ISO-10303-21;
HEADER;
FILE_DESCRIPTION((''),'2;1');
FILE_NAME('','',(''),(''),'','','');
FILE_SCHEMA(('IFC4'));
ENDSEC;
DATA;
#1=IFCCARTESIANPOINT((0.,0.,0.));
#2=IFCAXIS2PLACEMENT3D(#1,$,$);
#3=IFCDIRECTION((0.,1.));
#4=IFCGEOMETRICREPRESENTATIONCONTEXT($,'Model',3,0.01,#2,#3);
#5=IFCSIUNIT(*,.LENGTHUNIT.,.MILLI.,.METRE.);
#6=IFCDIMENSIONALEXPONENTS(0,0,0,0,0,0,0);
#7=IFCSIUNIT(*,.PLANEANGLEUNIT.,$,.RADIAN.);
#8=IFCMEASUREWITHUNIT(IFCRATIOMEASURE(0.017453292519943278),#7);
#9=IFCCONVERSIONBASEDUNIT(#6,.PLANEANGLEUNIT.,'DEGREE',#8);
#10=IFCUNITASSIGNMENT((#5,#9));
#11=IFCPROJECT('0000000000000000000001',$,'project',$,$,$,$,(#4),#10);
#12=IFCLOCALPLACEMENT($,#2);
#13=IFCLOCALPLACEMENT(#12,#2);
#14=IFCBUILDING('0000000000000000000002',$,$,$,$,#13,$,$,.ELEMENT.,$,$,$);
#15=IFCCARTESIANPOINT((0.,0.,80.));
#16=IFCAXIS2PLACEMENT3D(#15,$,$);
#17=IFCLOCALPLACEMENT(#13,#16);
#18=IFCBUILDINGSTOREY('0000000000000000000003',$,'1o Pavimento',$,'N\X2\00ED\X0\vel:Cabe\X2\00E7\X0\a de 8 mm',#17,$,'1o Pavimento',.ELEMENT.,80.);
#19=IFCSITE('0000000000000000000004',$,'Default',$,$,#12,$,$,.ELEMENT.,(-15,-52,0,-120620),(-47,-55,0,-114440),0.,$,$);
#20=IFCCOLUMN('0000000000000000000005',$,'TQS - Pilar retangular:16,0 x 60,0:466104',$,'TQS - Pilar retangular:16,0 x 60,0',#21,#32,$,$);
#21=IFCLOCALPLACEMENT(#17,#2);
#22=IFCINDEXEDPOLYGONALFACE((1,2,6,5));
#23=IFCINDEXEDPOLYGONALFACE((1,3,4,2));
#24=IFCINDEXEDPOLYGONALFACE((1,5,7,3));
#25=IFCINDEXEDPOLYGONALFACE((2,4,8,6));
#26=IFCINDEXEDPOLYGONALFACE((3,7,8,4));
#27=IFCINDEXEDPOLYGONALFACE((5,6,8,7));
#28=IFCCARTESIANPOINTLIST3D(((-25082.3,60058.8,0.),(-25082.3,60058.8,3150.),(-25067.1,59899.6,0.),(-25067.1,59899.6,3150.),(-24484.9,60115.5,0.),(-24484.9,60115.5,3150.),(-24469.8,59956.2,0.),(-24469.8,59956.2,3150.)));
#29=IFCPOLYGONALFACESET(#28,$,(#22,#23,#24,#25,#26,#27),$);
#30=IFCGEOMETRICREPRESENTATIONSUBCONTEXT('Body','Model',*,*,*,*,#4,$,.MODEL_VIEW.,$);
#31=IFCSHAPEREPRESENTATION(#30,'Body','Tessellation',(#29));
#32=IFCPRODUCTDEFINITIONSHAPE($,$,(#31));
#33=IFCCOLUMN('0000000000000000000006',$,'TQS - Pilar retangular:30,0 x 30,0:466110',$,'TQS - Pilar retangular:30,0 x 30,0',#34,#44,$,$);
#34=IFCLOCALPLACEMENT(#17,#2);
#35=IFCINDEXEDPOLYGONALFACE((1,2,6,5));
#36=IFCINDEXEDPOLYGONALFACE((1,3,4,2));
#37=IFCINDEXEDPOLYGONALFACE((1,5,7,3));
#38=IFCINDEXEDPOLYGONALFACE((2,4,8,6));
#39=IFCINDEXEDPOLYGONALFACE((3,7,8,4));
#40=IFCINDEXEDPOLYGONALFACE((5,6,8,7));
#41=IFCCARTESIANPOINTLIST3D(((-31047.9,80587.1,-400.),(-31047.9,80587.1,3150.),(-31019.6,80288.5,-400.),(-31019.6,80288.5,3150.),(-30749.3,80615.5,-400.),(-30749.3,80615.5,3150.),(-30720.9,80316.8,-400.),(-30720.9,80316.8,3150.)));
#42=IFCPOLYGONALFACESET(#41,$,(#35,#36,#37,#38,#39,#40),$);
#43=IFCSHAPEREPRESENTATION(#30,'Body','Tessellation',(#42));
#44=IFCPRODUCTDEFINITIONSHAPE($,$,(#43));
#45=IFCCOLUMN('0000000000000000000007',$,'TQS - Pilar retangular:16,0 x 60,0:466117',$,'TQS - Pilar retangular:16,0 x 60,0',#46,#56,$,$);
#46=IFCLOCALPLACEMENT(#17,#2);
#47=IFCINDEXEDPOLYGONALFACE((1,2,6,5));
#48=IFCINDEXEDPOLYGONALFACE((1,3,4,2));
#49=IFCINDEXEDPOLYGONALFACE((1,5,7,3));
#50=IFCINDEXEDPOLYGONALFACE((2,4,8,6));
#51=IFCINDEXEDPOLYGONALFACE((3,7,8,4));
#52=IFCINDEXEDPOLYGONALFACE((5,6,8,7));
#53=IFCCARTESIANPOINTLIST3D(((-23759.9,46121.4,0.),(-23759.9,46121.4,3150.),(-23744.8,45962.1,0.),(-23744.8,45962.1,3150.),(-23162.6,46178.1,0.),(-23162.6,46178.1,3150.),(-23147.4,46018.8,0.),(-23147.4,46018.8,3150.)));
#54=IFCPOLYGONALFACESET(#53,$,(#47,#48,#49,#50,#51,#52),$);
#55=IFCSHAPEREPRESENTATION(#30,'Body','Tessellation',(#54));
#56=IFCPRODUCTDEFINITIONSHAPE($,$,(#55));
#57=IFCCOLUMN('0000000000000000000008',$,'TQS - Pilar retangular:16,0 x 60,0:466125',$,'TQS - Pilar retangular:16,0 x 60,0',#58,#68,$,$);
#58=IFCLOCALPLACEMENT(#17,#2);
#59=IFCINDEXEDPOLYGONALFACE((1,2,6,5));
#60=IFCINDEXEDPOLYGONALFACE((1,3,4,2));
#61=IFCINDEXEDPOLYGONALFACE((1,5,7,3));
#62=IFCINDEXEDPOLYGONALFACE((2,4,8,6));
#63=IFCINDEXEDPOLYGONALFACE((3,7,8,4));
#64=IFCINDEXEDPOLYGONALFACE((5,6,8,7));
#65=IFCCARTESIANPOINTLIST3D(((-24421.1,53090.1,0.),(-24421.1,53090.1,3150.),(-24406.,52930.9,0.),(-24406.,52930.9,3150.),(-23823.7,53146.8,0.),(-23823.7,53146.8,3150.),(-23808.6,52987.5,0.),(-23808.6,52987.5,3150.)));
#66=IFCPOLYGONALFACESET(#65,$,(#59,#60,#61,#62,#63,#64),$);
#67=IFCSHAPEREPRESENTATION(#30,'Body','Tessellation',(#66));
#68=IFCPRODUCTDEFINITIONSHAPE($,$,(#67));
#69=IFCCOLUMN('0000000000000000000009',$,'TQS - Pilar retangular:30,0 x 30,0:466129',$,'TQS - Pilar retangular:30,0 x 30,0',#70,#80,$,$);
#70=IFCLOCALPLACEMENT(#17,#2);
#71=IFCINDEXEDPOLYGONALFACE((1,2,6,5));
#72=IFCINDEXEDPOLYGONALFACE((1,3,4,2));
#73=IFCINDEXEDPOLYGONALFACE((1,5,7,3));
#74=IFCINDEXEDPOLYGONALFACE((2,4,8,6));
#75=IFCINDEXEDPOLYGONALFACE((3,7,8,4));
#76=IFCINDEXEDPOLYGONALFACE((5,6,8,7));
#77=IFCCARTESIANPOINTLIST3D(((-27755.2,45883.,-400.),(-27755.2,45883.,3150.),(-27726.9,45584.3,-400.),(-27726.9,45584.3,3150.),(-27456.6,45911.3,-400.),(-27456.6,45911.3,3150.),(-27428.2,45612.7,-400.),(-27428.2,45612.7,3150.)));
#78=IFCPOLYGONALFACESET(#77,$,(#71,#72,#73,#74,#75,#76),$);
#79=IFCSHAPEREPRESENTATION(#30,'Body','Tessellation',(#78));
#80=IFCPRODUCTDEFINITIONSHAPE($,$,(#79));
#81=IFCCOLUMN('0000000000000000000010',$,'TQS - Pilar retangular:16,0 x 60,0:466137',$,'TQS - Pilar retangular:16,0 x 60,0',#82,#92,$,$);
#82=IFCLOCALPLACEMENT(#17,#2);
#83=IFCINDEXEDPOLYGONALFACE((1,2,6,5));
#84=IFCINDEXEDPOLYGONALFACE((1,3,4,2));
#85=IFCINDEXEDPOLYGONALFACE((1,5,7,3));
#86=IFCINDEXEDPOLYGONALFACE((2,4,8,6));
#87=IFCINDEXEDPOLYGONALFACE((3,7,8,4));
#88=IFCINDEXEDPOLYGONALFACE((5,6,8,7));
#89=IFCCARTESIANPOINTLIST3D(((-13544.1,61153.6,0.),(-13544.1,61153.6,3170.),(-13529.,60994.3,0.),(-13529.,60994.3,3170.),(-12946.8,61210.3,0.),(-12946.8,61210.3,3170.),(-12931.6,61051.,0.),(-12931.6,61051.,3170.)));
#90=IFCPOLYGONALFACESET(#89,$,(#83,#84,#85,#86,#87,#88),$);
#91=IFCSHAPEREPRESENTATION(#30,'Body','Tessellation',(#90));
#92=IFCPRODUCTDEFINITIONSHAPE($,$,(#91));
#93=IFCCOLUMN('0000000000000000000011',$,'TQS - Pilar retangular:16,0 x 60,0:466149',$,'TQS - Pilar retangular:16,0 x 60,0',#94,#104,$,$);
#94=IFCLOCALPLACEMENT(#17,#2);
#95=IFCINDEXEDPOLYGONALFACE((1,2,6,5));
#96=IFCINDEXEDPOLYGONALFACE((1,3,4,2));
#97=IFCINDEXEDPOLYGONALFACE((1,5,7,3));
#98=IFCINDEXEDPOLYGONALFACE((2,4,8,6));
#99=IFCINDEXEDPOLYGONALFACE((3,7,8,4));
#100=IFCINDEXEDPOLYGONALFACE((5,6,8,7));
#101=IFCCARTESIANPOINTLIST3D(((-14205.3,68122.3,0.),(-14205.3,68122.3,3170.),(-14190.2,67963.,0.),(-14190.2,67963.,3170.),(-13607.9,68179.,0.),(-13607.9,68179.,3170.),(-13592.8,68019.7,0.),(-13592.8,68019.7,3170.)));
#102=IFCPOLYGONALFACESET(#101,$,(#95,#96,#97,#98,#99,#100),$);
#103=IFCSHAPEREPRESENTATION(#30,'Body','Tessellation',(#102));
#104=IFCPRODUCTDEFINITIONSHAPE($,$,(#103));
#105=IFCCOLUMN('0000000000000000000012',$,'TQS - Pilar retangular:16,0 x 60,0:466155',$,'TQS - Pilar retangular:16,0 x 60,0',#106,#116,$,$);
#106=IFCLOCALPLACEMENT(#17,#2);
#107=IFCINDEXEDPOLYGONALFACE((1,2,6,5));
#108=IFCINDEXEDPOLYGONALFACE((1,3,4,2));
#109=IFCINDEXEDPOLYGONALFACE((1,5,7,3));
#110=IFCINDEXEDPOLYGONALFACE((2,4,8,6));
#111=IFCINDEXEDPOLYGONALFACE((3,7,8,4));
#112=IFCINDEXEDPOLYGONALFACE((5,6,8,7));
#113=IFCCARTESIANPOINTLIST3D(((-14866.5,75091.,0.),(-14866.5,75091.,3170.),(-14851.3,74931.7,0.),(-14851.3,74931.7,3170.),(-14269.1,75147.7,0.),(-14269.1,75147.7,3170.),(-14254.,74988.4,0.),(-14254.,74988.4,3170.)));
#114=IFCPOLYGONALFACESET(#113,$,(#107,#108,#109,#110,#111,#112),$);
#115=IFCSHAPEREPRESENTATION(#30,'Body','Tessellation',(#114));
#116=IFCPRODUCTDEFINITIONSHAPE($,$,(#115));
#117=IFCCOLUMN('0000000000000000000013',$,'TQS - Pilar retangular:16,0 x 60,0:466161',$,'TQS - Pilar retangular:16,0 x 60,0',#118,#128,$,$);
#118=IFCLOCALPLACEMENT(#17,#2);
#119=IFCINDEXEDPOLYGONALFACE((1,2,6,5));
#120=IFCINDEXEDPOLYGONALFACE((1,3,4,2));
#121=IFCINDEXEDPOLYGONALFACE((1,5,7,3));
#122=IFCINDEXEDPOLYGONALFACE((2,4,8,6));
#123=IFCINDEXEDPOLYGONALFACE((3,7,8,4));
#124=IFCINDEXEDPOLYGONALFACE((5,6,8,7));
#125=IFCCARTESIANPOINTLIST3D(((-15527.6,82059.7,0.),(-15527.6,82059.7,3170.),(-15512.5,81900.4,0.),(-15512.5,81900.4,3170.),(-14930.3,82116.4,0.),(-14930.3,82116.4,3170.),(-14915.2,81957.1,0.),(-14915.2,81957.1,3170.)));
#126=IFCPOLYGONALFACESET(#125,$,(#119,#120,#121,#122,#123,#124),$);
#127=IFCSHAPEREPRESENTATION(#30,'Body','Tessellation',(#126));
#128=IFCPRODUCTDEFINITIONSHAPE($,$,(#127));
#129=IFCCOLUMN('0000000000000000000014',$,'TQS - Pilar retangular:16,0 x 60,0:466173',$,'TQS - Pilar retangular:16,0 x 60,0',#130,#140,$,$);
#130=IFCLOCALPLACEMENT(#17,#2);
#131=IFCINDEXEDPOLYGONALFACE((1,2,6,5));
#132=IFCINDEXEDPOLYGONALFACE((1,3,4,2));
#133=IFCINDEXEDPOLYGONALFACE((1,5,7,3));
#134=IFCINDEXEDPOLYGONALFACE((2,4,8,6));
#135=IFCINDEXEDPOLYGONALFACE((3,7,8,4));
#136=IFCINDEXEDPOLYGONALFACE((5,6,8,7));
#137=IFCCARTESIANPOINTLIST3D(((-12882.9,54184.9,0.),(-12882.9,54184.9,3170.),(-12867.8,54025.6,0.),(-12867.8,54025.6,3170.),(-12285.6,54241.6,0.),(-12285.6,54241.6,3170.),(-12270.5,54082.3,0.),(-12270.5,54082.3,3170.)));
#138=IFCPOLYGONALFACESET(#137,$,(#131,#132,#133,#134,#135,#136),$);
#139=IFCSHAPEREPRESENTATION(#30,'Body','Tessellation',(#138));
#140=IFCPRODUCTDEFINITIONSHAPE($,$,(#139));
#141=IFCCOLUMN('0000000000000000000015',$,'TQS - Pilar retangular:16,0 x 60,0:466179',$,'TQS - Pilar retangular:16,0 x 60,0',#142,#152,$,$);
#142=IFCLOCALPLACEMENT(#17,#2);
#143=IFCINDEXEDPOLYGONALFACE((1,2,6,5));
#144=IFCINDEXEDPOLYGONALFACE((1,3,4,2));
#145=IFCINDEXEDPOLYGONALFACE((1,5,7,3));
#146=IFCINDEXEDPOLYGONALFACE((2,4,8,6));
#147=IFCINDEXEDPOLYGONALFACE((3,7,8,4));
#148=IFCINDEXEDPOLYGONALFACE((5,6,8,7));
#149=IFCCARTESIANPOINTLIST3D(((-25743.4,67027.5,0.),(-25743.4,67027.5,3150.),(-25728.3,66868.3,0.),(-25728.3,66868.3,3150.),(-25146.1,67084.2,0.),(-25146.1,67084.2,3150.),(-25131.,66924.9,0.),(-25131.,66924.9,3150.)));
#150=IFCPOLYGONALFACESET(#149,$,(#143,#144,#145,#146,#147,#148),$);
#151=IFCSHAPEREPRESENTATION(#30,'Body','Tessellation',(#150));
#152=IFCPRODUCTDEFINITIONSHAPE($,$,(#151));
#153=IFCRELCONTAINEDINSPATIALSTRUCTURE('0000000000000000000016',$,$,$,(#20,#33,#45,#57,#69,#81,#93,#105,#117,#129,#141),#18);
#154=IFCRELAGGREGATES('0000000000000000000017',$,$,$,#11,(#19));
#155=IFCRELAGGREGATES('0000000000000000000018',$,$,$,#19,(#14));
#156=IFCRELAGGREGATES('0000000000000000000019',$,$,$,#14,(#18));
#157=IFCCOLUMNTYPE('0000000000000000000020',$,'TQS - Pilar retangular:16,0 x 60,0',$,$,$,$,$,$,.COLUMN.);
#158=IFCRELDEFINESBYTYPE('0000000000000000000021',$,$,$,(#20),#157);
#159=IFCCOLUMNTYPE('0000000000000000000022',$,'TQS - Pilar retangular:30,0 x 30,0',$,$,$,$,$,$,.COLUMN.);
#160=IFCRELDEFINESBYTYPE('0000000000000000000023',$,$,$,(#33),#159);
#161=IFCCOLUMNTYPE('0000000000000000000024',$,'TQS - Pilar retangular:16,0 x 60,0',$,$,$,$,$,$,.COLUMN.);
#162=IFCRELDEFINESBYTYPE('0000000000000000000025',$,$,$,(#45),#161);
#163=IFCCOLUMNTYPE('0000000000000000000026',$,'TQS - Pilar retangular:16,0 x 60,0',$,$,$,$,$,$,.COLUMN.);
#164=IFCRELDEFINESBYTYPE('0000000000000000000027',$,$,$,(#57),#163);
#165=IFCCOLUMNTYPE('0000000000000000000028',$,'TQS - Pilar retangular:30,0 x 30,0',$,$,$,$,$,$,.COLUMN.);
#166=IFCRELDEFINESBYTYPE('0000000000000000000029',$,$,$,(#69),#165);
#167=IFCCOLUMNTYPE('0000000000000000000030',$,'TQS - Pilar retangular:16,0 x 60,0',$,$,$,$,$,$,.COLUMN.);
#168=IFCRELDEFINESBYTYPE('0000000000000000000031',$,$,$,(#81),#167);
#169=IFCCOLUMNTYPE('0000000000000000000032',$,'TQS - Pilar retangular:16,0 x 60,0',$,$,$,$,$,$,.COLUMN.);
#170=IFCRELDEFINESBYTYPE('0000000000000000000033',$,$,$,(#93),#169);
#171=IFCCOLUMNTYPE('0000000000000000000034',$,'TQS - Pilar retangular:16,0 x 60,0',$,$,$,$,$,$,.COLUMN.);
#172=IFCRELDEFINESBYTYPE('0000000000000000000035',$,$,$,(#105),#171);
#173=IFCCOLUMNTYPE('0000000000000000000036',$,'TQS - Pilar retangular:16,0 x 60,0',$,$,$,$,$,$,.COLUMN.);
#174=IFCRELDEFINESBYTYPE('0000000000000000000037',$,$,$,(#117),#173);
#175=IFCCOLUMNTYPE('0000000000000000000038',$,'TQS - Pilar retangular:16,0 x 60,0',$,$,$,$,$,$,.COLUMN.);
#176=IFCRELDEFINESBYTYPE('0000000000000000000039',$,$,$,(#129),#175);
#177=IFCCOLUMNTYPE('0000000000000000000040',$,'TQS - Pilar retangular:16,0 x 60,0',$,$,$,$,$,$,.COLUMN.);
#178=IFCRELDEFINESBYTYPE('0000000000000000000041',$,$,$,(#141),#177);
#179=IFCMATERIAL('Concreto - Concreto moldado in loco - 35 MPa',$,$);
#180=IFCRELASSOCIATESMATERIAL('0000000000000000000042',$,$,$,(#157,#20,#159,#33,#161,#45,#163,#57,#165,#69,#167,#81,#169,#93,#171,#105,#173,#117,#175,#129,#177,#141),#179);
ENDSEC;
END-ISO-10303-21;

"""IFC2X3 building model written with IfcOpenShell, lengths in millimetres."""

from ifc_helpers import new_model, entity, si_unit, converted_unit, direction, frame, frame_2d, origin, origin_2d_with_axis, place, context, subcontext, project, spatial, rectangle, extrude, source, transform, mapped, material, type_object, type_shapes, element, save


model = new_model("IFC2X3")

# Units and contexts
model_context = context("Model", 3, precision=0.01, world=origin(), true_north=direction((0.0, 1.0)))
body_context = subcontext(model_context, "Body", "Model", "MODEL_VIEW")
ifc_project = project(units=[si_unit("LENGTHUNIT", "METRE", prefix="MILLI"), converted_unit("PLANEANGLEUNIT", "DEGREE", entity("IfcRatioMeasure", 0.017453292519943278), si_unit("PLANEANGLEUNIT", "RADIAN"), dimensions=[0, 0, 0, 0, 0, 0, 0])], contexts=[model_context])

# Site, building, storey
site_placement = place(None, origin())
site = spatial("IfcSite", under=ifc_project, at=site_placement, Name="Default", CompositionType="ELEMENT", RefLatitude=(-15, -52, 0, -120620), RefLongitude=(-47, -55, 0, -114440), RefElevation=0.0)
building_placement = place(site_placement, origin())
building = spatial("IfcBuilding", under=site, at=building_placement, CompositionType="ELEMENT")
storey_placement = place(building_placement, frame((0.0, 0.0, 80.0)))
storey = spatial("IfcBuildingStorey", under=building, at=storey_placement, Name="1o Pavimento", ObjectType="Nível:Cabeça de 8 mm", LongName="1o Pavimento", CompositionType="ELEMENT", Elevation=80.0)

# Columns
ifc_material = material(Name="Concreto - Concreto moldado in loco - 35 MPa")
column_type_1 = type_object("IfcColumnType", Name="TQS - Pilar retangular:16,0 x 60,0", PredefinedType="COLUMN", material=ifc_material)
shared_shape_1 = source(origin(), body_context, "Body", "SweptSolid", [
    extrude(rectangle(XDim=600.0, YDim=160.0, at=origin_2d_with_axis()), frame((-24776.0, 60007.5, 80.0), z_axis=(0.0, 0.0, 1.0), x_axis=(-0.995529, -0.094456, 0.0)), (0.0, 0.0, 1.0), 3150.0),
])
type_shapes(column_type_1, [shared_shape_1])
column_1_placement = place(storey_placement, frame((0.0, 0.0, -80.0)))
element("IfcColumn", 1, at=column_1_placement, inside=storey, type_object=column_type_1, material=ifc_material, Name="TQS - Pilar retangular:16,0 x 60,0:466104", ObjectType="TQS - Pilar retangular:16,0 x 60,0", context=body_context, shape_type="MappedRepresentation", body=[
    mapped(shared_shape_1, transform((0.0, 0.0, 0.0), scale=1.0)),
])
column_type_2 = type_object("IfcColumnType", Name="TQS - Pilar retangular:30,0 x 30,0", PredefinedType="COLUMN", material=ifc_material)
shared_shape_2 = source(origin(), body_context, "Body", "SweptSolid", [
    extrude(rectangle(XDim=300.0, YDim=300.0, at=origin_2d_with_axis()), frame((-30884.4, 80452.0, -320.0), z_axis=(0.0, 0.0, 1.0), x_axis=(-0.995529, -0.094456, 0.0)), (0.0, 0.0, 1.0), 3550.0),
])
type_shapes(column_type_2, [shared_shape_2])
column_2_placement = place(storey_placement, frame((0.0, 0.0, -80.0)))
element("IfcColumn", 2, at=column_2_placement, inside=storey, type_object=column_type_2, material=ifc_material, Name="TQS - Pilar retangular:30,0 x 30,0:466110", ObjectType="TQS - Pilar retangular:30,0 x 30,0", context=body_context, shape_type="MappedRepresentation", body=[
    mapped(shared_shape_2, transform((0.0, 0.0, 0.0), scale=1.0)),
])
column_type_3 = type_object("IfcColumnType", Name="TQS - Pilar retangular:16,0 x 60,0", PredefinedType="COLUMN", material=ifc_material)
shared_shape_3 = source(origin(), body_context, "Body", "SweptSolid", [
    extrude(rectangle(XDim=600.0, YDim=160.0, at=origin_2d_with_axis()), frame((-23453.7, 46070.1, 80.0), z_axis=(0.0, 0.0, 1.0), x_axis=(-0.995529, -0.094456, 0.0)), (0.0, 0.0, 1.0), 3150.0),
])
type_shapes(column_type_3, [shared_shape_3])
column_3_placement = place(storey_placement, frame((0.0, 0.0, -80.0)))
element("IfcColumn", 3, at=column_3_placement, inside=storey, type_object=column_type_3, material=ifc_material, Name="TQS - Pilar retangular:16,0 x 60,0:466117", ObjectType="TQS - Pilar retangular:16,0 x 60,0", context=body_context, shape_type="MappedRepresentation", body=[
    mapped(shared_shape_3, transform((0.0, 0.0, 0.0), scale=1.0)),
])
column_type_4 = type_object("IfcColumnType", Name="TQS - Pilar retangular:16,0 x 60,0", PredefinedType="COLUMN", material=ifc_material)
shared_shape_4 = source(origin(), body_context, "Body", "SweptSolid", [
    extrude(rectangle(XDim=600.0, YDim=160.0, at=origin_2d_with_axis()), frame((-24114.9, 53038.8, 80.0), z_axis=(0.0, 0.0, 1.0), x_axis=(-0.995529, -0.094456, 0.0)), (0.0, 0.0, 1.0), 3150.0),
])
type_shapes(column_type_4, [shared_shape_4])
column_4_placement = place(storey_placement, frame((0.0, 0.0, -80.0)))
element("IfcColumn", 4, at=column_4_placement, inside=storey, type_object=column_type_4, material=ifc_material, Name="TQS - Pilar retangular:16,0 x 60,0:466125", ObjectType="TQS - Pilar retangular:16,0 x 60,0", context=body_context, shape_type="MappedRepresentation", body=[
    mapped(shared_shape_4, transform((0.0, 0.0, 0.0), scale=1.0)),
])
column_type_5 = type_object("IfcColumnType", Name="TQS - Pilar retangular:30,0 x 30,0", PredefinedType="COLUMN", material=ifc_material)
shared_shape_5 = source(origin(), body_context, "Body", "SweptSolid", [
    extrude(rectangle(XDim=300.0, YDim=300.0, at=origin_2d_with_axis()), frame((-27591.7, 45747.8, -320.0), z_axis=(0.0, 0.0, 1.0), x_axis=(-0.995529, -0.094456, 0.0)), (0.0, 0.0, 1.0), 3550.0),
])
type_shapes(column_type_5, [shared_shape_5])
column_5_placement = place(storey_placement, frame((0.0, 0.0, -80.0)))
element("IfcColumn", 5, at=column_5_placement, inside=storey, type_object=column_type_5, material=ifc_material, Name="TQS - Pilar retangular:30,0 x 30,0:466129", ObjectType="TQS - Pilar retangular:30,0 x 30,0", context=body_context, shape_type="MappedRepresentation", body=[
    mapped(shared_shape_5, transform((0.0, 0.0, 0.0), scale=1.0)),
])
column_type_6 = type_object("IfcColumnType", Name="TQS - Pilar retangular:16,0 x 60,0", PredefinedType="COLUMN", material=ifc_material)
shared_shape_6 = source(origin(), body_context, "Body", "SweptSolid", [
    extrude(rectangle(XDim=600.0, YDim=160.0, at=frame_2d((0.0, 0.0), x_axis=(1.0, 0.0))), frame((-13237.9, 61102.3, 80.0), z_axis=(0.0, 0.0, 1.0), x_axis=(-0.995529, -0.094456, 0.0)), (0.0, 0.0, 1.0), 3170.0),
])
type_shapes(column_type_6, [shared_shape_6])
column_6_placement = place(storey_placement, frame((0.0, 0.0, -80.0)))
element("IfcColumn", 6, at=column_6_placement, inside=storey, type_object=column_type_6, material=ifc_material, Name="TQS - Pilar retangular:16,0 x 60,0:466137", ObjectType="TQS - Pilar retangular:16,0 x 60,0", context=body_context, shape_type="MappedRepresentation", body=[
    mapped(shared_shape_6, transform((0.0, 0.0, 0.0), scale=1.0)),
])
column_type_7 = type_object("IfcColumnType", Name="TQS - Pilar retangular:16,0 x 60,0", PredefinedType="COLUMN", material=ifc_material)
shared_shape_7 = source(origin(), body_context, "Body", "SweptSolid", [
    extrude(rectangle(XDim=600.0, YDim=160.0, at=frame_2d((0.0, 0.0), x_axis=(1.0, 0.0))), frame((-13899.1, 68071.0, 80.0), z_axis=(0.0, 0.0, 1.0), x_axis=(-0.995529, -0.094456, 0.0)), (0.0, 0.0, 1.0), 3170.0),
])
type_shapes(column_type_7, [shared_shape_7])
column_7_placement = place(storey_placement, frame((0.0, 0.0, -80.0)))
element("IfcColumn", 7, at=column_7_placement, inside=storey, type_object=column_type_7, material=ifc_material, Name="TQS - Pilar retangular:16,0 x 60,0:466149", ObjectType="TQS - Pilar retangular:16,0 x 60,0", context=body_context, shape_type="MappedRepresentation", body=[
    mapped(shared_shape_7, transform((0.0, 0.0, 0.0), scale=1.0)),
])
column_type_8 = type_object("IfcColumnType", Name="TQS - Pilar retangular:16,0 x 60,0", PredefinedType="COLUMN", material=ifc_material)
shared_shape_8 = source(origin(), body_context, "Body", "SweptSolid", [
    extrude(rectangle(XDim=600.0, YDim=160.0, at=frame_2d((0.0, 0.0), x_axis=(1.0, 0.0))), frame((-14560.2, 75039.7, 80.0), z_axis=(0.0, 0.0, 1.0), x_axis=(-0.995529, -0.094456, 0.0)), (0.0, 0.0, 1.0), 3170.0),
])
type_shapes(column_type_8, [shared_shape_8])
column_8_placement = place(storey_placement, frame((0.0, 0.0, -80.0)))
element("IfcColumn", 8, at=column_8_placement, inside=storey, type_object=column_type_8, material=ifc_material, Name="TQS - Pilar retangular:16,0 x 60,0:466155", ObjectType="TQS - Pilar retangular:16,0 x 60,0", context=body_context, shape_type="MappedRepresentation", body=[
    mapped(shared_shape_8, transform((0.0, 0.0, 0.0), scale=1.0)),
])
column_type_9 = type_object("IfcColumnType", Name="TQS - Pilar retangular:16,0 x 60,0", PredefinedType="COLUMN", material=ifc_material)
shared_shape_9 = source(origin(), body_context, "Body", "SweptSolid", [
    extrude(rectangle(XDim=600.0, YDim=160.0, at=frame_2d((0.0, 0.0), x_axis=(1.0, 0.0))), frame((-15221.4, 82008.4, 80.0), z_axis=(0.0, 0.0, 1.0), x_axis=(-0.995529, -0.094456, 0.0)), (0.0, 0.0, 1.0), 3170.0),
])
type_shapes(column_type_9, [shared_shape_9])
column_9_placement = place(storey_placement, frame((0.0, 0.0, -80.0)))
element("IfcColumn", 9, at=column_9_placement, inside=storey, type_object=column_type_9, material=ifc_material, Name="TQS - Pilar retangular:16,0 x 60,0:466161", ObjectType="TQS - Pilar retangular:16,0 x 60,0", context=body_context, shape_type="MappedRepresentation", body=[
    mapped(shared_shape_9, transform((0.0, 0.0, 0.0), scale=1.0)),
])
column_type_10 = type_object("IfcColumnType", Name="TQS - Pilar retangular:16,0 x 60,0", PredefinedType="COLUMN", material=ifc_material)
shared_shape_10 = source(origin(), body_context, "Body", "SweptSolid", [
    extrude(rectangle(XDim=600.0, YDim=160.0, at=frame_2d((0.0, 0.0), x_axis=(1.0, 0.0))), frame((-12576.7, 54133.6, 80.0), z_axis=(0.0, 0.0, 1.0), x_axis=(-0.995529, -0.094456, 0.0)), (0.0, 0.0, 1.0), 3170.0),
])
type_shapes(column_type_10, [shared_shape_10])
column_10_placement = place(storey_placement, frame((0.0, 0.0, -80.0)))
element("IfcColumn", 10, at=column_10_placement, inside=storey, type_object=column_type_10, material=ifc_material, Name="TQS - Pilar retangular:16,0 x 60,0:466173", ObjectType="TQS - Pilar retangular:16,0 x 60,0", context=body_context, shape_type="MappedRepresentation", body=[
    mapped(shared_shape_10, transform((0.0, 0.0, 0.0), scale=1.0)),
])
column_type_11 = type_object("IfcColumnType", Name="TQS - Pilar retangular:16,0 x 60,0", PredefinedType="COLUMN", material=ifc_material)
shared_shape_11 = source(origin(), body_context, "Body", "SweptSolid", [
    extrude(rectangle(XDim=600.0, YDim=160.0, at=origin_2d_with_axis()), frame((-25437.2, 66976.2, 80.0), z_axis=(0.0, 0.0, 1.0), x_axis=(-0.995529, -0.094456, 0.0)), (0.0, 0.0, 1.0), 3150.0),
])
type_shapes(column_type_11, [shared_shape_11])
column_11_placement = place(storey_placement, frame((0.0, 0.0, -80.0)))
element("IfcColumn", 11, at=column_11_placement, inside=storey, type_object=column_type_11, material=ifc_material, Name="TQS - Pilar retangular:16,0 x 60,0:466179", ObjectType="TQS - Pilar retangular:16,0 x 60,0", context=body_context, shape_type="MappedRepresentation", body=[
    mapped(shared_shape_11, transform((0.0, 0.0, 0.0), scale=1.0)),
])

save(model, "model.ifc")
